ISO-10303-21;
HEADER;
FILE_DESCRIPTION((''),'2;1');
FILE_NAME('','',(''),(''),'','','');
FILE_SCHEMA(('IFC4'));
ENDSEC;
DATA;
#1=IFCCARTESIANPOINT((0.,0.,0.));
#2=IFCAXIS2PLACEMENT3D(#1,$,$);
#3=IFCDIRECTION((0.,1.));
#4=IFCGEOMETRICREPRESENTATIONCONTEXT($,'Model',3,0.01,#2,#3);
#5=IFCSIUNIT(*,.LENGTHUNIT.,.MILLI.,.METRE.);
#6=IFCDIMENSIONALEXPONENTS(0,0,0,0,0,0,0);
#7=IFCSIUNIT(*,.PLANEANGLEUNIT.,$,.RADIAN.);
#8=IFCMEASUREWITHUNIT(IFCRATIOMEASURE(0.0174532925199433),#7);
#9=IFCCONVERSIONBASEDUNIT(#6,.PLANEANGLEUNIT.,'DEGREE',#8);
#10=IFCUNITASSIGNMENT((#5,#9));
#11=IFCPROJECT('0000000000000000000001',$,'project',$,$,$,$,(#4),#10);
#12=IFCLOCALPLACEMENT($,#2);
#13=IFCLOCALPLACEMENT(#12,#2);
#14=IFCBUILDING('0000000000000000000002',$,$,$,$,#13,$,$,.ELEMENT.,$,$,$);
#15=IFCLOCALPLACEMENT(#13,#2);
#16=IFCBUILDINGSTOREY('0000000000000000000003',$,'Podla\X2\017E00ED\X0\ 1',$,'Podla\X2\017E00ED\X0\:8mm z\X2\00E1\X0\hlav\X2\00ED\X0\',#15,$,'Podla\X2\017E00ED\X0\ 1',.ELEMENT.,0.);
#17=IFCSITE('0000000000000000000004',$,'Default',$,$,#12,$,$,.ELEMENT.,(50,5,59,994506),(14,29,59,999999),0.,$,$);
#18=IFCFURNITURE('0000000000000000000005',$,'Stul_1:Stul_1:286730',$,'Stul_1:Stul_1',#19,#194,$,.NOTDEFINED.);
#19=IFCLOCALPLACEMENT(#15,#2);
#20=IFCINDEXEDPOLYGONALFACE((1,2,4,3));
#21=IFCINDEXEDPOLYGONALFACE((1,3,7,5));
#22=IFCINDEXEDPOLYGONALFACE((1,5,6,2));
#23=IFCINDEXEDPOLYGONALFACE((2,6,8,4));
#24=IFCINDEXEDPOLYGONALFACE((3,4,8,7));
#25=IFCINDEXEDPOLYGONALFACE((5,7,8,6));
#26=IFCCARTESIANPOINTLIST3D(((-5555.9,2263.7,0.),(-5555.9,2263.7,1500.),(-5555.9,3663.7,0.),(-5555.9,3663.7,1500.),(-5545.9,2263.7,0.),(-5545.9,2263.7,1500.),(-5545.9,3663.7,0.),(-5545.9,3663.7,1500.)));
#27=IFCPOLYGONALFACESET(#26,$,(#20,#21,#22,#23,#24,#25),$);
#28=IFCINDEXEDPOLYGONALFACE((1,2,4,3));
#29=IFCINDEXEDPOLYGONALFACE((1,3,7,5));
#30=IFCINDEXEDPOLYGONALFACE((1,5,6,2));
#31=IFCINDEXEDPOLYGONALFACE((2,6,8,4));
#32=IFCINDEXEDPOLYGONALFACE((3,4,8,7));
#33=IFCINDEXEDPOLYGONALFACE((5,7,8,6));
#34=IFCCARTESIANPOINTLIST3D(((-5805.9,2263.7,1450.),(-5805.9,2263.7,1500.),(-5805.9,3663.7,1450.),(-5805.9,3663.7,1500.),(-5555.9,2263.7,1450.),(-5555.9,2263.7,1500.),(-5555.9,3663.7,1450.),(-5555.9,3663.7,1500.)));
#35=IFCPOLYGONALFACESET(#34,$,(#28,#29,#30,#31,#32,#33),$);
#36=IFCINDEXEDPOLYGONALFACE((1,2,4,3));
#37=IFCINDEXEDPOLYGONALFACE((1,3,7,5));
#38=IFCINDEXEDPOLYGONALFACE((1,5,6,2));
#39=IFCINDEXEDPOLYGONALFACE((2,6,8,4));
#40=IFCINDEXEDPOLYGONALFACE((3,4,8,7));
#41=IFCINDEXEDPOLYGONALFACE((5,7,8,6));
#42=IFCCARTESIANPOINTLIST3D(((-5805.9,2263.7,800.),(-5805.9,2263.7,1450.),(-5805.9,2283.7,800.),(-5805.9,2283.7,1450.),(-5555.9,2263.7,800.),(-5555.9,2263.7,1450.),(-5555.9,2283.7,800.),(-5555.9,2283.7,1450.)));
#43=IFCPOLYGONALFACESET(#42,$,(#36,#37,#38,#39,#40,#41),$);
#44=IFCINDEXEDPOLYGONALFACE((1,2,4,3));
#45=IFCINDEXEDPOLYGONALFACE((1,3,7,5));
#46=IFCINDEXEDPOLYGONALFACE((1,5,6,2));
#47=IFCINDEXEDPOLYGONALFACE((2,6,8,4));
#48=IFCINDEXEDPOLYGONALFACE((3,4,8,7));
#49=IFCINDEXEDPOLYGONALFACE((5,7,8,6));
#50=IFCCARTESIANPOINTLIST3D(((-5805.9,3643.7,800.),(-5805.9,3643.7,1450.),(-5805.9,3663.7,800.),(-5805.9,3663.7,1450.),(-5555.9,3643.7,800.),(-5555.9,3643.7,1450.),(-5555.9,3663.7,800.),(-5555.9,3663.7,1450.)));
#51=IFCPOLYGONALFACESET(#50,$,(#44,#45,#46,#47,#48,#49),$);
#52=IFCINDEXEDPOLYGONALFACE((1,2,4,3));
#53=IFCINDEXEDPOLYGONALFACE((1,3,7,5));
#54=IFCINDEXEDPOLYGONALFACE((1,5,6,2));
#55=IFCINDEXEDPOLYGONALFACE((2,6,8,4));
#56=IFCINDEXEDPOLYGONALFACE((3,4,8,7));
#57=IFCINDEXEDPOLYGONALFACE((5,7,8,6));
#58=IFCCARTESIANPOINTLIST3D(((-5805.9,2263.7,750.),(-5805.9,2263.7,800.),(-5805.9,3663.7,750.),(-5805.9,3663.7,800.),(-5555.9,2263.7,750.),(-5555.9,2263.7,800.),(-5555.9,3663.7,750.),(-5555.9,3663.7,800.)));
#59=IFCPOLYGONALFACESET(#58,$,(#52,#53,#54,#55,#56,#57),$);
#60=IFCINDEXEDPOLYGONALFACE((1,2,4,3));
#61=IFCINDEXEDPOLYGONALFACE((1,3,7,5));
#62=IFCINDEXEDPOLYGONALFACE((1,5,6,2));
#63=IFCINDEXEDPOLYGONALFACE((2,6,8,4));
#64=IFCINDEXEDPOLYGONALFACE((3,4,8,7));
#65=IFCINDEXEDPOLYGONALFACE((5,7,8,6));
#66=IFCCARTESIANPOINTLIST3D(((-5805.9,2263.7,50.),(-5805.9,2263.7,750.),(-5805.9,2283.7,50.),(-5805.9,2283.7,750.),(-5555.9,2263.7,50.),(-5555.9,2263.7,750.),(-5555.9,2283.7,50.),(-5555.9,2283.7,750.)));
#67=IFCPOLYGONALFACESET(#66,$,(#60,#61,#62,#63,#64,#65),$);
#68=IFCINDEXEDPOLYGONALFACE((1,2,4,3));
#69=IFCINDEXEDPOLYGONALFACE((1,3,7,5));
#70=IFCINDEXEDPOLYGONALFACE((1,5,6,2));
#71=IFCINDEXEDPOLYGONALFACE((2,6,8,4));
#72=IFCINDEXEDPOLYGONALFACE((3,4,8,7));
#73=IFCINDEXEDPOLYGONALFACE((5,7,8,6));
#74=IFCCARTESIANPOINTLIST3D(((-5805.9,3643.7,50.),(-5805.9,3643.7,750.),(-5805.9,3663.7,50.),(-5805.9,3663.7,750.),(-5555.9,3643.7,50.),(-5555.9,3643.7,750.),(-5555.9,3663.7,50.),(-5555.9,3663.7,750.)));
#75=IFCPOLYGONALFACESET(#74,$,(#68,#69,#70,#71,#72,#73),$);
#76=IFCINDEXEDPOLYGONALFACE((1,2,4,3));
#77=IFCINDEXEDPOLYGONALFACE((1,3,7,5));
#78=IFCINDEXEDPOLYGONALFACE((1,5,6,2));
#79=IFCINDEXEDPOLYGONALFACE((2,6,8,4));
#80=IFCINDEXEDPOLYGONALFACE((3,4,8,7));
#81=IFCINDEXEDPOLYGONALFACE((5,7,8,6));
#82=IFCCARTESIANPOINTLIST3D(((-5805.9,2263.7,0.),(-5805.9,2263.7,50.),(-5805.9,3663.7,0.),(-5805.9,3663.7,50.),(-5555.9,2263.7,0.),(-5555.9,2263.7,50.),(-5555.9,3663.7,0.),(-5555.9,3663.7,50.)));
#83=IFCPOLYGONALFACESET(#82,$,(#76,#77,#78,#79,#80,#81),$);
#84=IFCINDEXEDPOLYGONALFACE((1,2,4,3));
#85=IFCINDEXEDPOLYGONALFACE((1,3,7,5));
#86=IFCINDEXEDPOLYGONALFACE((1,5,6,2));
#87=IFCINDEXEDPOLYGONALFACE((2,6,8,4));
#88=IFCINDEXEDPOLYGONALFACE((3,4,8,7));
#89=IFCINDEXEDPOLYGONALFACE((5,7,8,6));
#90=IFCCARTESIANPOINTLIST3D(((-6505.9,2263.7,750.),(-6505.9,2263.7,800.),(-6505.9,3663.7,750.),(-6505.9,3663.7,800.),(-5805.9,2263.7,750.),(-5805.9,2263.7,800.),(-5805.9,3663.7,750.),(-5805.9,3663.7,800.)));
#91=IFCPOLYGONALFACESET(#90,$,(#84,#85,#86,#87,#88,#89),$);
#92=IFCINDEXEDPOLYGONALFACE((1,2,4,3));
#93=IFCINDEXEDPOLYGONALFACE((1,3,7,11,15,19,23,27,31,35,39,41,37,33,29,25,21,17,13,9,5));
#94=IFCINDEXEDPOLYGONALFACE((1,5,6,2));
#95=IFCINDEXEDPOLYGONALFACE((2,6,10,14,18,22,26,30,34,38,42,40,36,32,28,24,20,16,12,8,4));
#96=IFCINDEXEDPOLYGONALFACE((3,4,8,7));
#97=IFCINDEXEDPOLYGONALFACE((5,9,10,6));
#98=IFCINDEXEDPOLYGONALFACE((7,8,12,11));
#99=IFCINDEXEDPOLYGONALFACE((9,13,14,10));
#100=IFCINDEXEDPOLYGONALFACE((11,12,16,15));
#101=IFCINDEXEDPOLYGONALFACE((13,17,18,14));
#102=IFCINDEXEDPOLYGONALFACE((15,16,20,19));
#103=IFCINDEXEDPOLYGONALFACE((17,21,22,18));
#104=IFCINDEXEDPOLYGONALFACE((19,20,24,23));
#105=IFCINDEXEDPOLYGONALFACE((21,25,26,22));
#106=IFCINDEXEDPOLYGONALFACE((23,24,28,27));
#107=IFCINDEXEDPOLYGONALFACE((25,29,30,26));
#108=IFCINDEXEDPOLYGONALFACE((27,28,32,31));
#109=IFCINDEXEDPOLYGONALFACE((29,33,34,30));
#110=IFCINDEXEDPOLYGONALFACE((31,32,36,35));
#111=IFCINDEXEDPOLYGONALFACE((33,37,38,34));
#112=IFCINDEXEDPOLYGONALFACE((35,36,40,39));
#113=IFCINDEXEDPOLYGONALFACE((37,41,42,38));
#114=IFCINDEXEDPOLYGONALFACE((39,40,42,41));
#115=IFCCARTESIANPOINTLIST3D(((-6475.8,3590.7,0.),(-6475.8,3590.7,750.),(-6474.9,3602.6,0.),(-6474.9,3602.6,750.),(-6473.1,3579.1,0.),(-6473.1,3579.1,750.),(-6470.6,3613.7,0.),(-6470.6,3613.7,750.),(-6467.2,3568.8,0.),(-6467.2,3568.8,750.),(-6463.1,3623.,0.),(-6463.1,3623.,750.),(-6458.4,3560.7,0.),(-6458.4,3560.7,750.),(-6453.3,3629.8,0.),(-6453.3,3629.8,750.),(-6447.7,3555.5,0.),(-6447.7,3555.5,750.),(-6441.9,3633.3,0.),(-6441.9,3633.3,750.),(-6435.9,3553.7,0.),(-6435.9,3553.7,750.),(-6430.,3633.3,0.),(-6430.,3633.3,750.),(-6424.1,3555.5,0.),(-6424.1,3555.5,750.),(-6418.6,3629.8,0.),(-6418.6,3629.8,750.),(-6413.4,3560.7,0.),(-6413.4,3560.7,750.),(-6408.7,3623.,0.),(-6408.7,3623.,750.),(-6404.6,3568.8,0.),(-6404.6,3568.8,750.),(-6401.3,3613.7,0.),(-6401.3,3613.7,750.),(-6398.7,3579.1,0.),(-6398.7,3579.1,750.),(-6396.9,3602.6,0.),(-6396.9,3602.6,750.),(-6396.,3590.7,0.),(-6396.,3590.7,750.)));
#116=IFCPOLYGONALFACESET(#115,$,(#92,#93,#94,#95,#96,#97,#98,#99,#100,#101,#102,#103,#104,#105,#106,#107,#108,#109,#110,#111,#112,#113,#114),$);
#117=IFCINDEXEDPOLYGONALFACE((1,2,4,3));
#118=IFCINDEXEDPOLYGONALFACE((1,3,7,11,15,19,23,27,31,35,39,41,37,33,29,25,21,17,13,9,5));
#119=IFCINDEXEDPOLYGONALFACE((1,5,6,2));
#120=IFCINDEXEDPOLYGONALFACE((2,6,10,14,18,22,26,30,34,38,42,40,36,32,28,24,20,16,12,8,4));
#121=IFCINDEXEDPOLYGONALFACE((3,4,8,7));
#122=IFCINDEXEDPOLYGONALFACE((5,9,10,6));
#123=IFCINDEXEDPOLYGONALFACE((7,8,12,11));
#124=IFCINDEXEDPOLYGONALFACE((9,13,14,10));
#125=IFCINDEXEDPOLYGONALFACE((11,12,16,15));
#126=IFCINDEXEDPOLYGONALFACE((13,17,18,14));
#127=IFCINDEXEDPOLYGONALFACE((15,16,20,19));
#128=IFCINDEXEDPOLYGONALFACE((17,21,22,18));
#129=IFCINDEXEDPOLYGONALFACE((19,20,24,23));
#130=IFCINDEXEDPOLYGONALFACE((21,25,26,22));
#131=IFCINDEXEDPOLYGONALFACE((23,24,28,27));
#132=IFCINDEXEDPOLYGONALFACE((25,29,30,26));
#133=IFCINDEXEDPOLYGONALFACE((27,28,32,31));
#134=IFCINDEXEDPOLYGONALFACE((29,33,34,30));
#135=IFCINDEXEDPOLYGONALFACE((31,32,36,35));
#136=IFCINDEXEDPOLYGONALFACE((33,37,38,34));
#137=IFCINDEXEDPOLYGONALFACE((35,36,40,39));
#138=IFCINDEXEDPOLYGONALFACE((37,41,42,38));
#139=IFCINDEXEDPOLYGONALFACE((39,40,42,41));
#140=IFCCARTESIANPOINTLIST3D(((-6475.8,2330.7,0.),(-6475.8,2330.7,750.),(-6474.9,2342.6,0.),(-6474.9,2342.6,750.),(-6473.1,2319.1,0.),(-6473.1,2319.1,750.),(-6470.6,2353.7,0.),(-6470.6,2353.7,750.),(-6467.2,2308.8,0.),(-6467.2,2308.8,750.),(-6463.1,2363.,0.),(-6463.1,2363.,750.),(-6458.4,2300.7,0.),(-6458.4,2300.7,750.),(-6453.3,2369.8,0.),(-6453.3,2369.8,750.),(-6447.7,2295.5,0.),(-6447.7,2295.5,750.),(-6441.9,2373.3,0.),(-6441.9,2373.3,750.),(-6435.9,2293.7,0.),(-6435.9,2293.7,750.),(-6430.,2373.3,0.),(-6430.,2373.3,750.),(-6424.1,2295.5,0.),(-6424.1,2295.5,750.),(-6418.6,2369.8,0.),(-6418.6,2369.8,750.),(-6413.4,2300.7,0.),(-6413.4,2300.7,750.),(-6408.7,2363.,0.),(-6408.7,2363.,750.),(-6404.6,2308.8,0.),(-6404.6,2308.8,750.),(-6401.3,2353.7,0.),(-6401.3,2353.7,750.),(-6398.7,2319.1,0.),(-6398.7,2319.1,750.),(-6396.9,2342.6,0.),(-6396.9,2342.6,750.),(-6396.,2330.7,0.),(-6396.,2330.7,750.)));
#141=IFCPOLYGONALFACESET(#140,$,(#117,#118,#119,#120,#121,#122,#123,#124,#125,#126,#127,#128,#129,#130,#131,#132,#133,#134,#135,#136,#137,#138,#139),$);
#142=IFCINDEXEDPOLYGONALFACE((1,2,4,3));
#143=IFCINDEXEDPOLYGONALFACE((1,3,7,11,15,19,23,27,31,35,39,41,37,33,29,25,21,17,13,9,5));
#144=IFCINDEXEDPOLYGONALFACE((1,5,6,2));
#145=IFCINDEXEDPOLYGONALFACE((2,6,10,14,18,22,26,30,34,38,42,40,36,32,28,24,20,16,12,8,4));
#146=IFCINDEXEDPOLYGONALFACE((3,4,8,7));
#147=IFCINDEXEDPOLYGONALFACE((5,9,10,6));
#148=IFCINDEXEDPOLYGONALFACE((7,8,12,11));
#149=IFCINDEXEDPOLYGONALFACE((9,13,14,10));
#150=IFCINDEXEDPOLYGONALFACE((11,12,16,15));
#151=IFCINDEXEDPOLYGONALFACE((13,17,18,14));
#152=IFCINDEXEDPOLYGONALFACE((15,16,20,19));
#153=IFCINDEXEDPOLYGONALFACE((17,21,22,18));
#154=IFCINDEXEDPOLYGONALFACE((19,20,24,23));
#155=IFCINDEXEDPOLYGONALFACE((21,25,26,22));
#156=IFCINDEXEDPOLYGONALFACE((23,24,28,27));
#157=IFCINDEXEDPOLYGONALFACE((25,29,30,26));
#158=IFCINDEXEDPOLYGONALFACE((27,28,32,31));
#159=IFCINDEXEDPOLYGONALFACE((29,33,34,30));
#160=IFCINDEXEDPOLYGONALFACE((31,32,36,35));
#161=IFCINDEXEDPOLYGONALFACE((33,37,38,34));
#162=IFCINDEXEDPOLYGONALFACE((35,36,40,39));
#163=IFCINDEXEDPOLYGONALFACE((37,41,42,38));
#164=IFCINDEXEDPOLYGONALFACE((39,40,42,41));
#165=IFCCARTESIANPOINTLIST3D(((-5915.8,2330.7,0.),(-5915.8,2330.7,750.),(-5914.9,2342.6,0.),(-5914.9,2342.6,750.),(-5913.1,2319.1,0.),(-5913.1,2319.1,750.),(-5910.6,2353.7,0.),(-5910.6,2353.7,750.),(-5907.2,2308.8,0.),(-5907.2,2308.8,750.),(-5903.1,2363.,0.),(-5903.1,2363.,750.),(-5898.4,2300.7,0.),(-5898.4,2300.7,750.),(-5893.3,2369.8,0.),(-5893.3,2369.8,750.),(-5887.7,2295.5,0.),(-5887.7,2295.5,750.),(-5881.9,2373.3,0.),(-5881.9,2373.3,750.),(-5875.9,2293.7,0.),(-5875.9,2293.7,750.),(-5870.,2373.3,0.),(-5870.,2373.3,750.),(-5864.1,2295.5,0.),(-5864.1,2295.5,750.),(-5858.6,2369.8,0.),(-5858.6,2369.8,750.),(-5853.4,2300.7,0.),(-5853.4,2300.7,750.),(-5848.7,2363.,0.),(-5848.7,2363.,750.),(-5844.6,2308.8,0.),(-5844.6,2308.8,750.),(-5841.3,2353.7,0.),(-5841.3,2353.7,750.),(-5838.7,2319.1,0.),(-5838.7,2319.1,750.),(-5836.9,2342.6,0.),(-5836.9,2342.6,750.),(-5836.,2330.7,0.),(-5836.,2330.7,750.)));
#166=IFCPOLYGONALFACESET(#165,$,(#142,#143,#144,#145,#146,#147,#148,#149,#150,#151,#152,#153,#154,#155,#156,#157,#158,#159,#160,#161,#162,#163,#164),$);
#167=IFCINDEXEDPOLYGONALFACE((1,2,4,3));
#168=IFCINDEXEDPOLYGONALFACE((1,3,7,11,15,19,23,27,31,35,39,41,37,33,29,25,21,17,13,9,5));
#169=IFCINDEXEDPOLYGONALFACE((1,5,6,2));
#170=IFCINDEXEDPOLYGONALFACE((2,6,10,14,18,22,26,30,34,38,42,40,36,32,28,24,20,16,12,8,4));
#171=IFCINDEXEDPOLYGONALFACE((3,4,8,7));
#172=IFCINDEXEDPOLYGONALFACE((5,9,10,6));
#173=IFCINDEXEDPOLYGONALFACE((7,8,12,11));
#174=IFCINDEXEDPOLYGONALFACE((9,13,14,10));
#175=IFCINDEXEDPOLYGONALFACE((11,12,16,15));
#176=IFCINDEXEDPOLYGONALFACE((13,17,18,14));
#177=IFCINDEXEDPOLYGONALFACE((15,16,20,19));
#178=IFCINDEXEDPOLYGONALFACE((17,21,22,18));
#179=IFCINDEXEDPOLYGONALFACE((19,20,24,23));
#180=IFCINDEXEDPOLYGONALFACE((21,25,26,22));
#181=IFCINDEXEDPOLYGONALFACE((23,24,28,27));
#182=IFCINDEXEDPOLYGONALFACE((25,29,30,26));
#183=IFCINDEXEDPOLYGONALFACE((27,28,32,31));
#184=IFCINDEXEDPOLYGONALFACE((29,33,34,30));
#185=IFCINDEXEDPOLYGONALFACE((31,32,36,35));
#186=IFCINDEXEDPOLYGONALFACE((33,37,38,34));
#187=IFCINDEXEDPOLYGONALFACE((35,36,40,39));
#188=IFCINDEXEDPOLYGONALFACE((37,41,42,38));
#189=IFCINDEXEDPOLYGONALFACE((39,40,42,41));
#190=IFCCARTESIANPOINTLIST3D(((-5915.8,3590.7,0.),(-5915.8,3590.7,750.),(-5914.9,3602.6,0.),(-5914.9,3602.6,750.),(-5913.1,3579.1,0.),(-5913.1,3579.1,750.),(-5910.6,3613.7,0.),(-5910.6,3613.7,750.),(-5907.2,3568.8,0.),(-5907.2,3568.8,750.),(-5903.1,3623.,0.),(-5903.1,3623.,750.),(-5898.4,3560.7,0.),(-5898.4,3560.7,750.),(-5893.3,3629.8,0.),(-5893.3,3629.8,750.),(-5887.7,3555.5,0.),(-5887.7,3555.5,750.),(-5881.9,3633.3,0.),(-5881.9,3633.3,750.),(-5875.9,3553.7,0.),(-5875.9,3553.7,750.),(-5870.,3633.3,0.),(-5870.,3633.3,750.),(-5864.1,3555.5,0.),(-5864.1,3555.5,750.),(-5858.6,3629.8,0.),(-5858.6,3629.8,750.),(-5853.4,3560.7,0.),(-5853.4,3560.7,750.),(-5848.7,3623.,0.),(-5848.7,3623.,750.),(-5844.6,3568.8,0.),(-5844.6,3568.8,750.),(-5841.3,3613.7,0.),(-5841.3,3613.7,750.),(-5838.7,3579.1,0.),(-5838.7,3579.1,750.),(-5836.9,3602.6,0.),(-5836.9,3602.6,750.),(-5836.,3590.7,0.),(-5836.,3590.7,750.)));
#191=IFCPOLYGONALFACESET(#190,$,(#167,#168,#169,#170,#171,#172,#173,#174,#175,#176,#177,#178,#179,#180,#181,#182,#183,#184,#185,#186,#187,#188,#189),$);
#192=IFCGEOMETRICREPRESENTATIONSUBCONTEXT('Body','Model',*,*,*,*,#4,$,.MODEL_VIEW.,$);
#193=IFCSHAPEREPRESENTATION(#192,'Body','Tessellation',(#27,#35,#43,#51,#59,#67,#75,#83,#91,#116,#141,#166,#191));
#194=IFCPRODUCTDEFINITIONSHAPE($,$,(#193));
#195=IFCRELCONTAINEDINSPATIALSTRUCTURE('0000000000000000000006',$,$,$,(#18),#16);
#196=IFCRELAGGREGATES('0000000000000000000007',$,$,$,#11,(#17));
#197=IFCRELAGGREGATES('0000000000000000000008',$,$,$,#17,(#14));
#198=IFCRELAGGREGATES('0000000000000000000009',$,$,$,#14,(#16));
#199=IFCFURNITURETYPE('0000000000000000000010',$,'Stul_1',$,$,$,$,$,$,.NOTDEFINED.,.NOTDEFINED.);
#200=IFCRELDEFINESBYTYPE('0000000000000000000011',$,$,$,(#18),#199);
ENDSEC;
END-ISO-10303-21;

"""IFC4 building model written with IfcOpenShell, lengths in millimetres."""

from ifc_helpers import new_model, entity, si_unit, converted_unit, direction, frame, frame_2d, origin, origin_2d_with_axis, place, context, subcontext, project, spatial, rectangle, circle, extrude, source, transform, mapped, type_object, type_shapes, element, save


model = new_model("IFC4")

# Units and contexts
model_context = context("Model", 3, precision=0.01, world=origin(), true_north=direction((0.0, 1.0)))
body_context = subcontext(model_context, "Body", "Model", "MODEL_VIEW")
ifc_project = project(units=[si_unit("LENGTHUNIT", "METRE", prefix="MILLI"), converted_unit("PLANEANGLEUNIT", "DEGREE", entity("IfcRatioMeasure", 0.0174532925199433), si_unit("PLANEANGLEUNIT", "RADIAN"), dimensions=[0, 0, 0, 0, 0, 0, 0])], contexts=[model_context])

# Site, building, storey
site_placement = place(None, origin())
site = spatial("IfcSite", under=ifc_project, at=site_placement, Name="Default", CompositionType="ELEMENT", RefLatitude=(50, 5, 59, 994506), RefLongitude=(14, 29, 59, 999999), RefElevation=0.0)
building_placement = place(site_placement, origin())
building = spatial("IfcBuilding", under=site, at=building_placement, CompositionType="ELEMENT")
storey_placement = place(building_placement, origin())
storey = spatial("IfcBuildingStorey", under=building, at=storey_placement, Name="Podlaží 1", ObjectType="Podlaží:8mm záhlaví", LongName="Podlaží 1", CompositionType="ELEMENT", Elevation=0.0)

# Furniture
furniture_type = type_object("IfcFurnitureType", Name="Stul_1", AssemblyPlace="NOTDEFINED", PredefinedType="NOTDEFINED")
shared_shape_1 = source(origin(), body_context, "Body", "SweptSolid", [
    extrude(rectangle(XDim=1400.0, YDim=10.0, at=origin_2d_with_axis()), frame((0.0, 605.0, 0.0), z_axis=(0.0, 0.0, 1.0), x_axis=(-1.0, 0.0, 0.0)), (0.0, 0.0, 1.0), 1500.0),
    extrude(rectangle(XDim=1400.0, YDim=250.0, at=frame_2d((0.0, 0.0), x_axis=(1.0, 0.0))), frame((0.0, 475.0, 1450.0), z_axis=(0.0, 0.0, 1.0), x_axis=(-1.0, 0.0, 0.0)), (0.0, 0.0, 1.0), 50.0),
    extrude(rectangle(XDim=20.0, YDim=250.0, at=origin_2d_with_axis()), frame((690.0, 475.0, 800.0), z_axis=(0.0, 0.0, 1.0), x_axis=(-1.0, 0.0, 0.0)), (0.0, 0.0, 1.0), 650.0),
    extrude(rectangle(XDim=20.0, YDim=250.0, at=frame_2d((0.0, 0.0), x_axis=(1.0, 0.0))), frame((-690.0, 475.0, 800.0), z_axis=(0.0, 0.0, 1.0), x_axis=(-1.0, 0.0, 0.0)), (0.0, 0.0, 1.0), 650.0),
    extrude(rectangle(XDim=1400.0, YDim=250.0, at=origin_2d_with_axis()), frame((0.0, 475.0, 750.0), z_axis=(0.0, 0.0, 1.0), x_axis=(-1.0, 0.0, 0.0)), (0.0, 0.0, 1.0), 50.0),
    extrude(rectangle(XDim=20.0, YDim=250.0, at=origin_2d_with_axis()), frame((690.0, 475.0, 50.0), z_axis=(0.0, 0.0, 1.0), x_axis=(-1.0, 0.0, 0.0)), (0.0, 0.0, 1.0), 700.0),
    extrude(rectangle(XDim=20.0, YDim=250.0, at=frame_2d((0.0, 0.0), x_axis=(1.0, 0.0))), frame((-690.0, 475.0, 50.0), z_axis=(0.0, 0.0, 1.0), x_axis=(-1.0, 0.0, 0.0)), (0.0, 0.0, 1.0), 700.0),
    extrude(rectangle(XDim=1400.0, YDim=250.0, at=origin_2d_with_axis()), frame((0.0, 475.0, 0.0), z_axis=(0.0, 0.0, 1.0), x_axis=(-1.0, 0.0, 0.0)), (0.0, 0.0, 1.0), 50.0),
    extrude(rectangle(XDim=1400.0, YDim=700.0, at=origin_2d_with_axis()), frame((0.0, 0.0, 750.0), z_axis=(0.0, 0.0, 1.0), x_axis=(-1.0, 0.0, 0.0)), (0.0, 0.0, 1.0), 50.0),
    extrude(circle(Radius=40.0, at=frame_2d((0.0, 0.0), x_axis=(1.0, 0.0))), frame((-630.0, -280.0, 0.0)), (0.0, 0.0, 1.0), 750.0),
    extrude(circle(Radius=40.0, at=frame_2d((0.0, 0.0), x_axis=(1.0, 0.0))), frame((630.0, -280.0, 0.0)), (0.0, 0.0, 1.0), 750.0),
    extrude(circle(Radius=40.0, at=frame_2d((0.0, 0.0), x_axis=(1.0, 0.0))), frame((630.0, 280.0, 0.0)), (0.0, 0.0, 1.0), 750.0),
    extrude(circle(Radius=40.0, at=frame_2d((0.0, 0.0), x_axis=(1.0, 0.0))), frame((-630.0, 280.0, 0.0)), (0.0, 0.0, 1.0), 750.0),
])
type_shapes(furniture_type, [shared_shape_1])
for number, where, z_axis, x_axis, name in (
    (1, (-6155.9, 2963.7, 0.0), (0.0, 0.0, 1.0), (0.0, -1.0, 0.0), "Stul_1:Stul_1:286730"),
):
    element("IfcFurniture", number, at=place(storey_placement, frame(where, z_axis=z_axis, x_axis=x_axis)), inside=storey, type_object=furniture_type, Name=name, ObjectType="Stul_1:Stul_1", PredefinedType="NOTDEFINED", context=body_context, shape_type="MappedRepresentation", body=[
        mapped(shared_shape_1, transform((0.0, 0.0, 0.0), scale=1.0)),
    ])

save(model, "model.ifc")
